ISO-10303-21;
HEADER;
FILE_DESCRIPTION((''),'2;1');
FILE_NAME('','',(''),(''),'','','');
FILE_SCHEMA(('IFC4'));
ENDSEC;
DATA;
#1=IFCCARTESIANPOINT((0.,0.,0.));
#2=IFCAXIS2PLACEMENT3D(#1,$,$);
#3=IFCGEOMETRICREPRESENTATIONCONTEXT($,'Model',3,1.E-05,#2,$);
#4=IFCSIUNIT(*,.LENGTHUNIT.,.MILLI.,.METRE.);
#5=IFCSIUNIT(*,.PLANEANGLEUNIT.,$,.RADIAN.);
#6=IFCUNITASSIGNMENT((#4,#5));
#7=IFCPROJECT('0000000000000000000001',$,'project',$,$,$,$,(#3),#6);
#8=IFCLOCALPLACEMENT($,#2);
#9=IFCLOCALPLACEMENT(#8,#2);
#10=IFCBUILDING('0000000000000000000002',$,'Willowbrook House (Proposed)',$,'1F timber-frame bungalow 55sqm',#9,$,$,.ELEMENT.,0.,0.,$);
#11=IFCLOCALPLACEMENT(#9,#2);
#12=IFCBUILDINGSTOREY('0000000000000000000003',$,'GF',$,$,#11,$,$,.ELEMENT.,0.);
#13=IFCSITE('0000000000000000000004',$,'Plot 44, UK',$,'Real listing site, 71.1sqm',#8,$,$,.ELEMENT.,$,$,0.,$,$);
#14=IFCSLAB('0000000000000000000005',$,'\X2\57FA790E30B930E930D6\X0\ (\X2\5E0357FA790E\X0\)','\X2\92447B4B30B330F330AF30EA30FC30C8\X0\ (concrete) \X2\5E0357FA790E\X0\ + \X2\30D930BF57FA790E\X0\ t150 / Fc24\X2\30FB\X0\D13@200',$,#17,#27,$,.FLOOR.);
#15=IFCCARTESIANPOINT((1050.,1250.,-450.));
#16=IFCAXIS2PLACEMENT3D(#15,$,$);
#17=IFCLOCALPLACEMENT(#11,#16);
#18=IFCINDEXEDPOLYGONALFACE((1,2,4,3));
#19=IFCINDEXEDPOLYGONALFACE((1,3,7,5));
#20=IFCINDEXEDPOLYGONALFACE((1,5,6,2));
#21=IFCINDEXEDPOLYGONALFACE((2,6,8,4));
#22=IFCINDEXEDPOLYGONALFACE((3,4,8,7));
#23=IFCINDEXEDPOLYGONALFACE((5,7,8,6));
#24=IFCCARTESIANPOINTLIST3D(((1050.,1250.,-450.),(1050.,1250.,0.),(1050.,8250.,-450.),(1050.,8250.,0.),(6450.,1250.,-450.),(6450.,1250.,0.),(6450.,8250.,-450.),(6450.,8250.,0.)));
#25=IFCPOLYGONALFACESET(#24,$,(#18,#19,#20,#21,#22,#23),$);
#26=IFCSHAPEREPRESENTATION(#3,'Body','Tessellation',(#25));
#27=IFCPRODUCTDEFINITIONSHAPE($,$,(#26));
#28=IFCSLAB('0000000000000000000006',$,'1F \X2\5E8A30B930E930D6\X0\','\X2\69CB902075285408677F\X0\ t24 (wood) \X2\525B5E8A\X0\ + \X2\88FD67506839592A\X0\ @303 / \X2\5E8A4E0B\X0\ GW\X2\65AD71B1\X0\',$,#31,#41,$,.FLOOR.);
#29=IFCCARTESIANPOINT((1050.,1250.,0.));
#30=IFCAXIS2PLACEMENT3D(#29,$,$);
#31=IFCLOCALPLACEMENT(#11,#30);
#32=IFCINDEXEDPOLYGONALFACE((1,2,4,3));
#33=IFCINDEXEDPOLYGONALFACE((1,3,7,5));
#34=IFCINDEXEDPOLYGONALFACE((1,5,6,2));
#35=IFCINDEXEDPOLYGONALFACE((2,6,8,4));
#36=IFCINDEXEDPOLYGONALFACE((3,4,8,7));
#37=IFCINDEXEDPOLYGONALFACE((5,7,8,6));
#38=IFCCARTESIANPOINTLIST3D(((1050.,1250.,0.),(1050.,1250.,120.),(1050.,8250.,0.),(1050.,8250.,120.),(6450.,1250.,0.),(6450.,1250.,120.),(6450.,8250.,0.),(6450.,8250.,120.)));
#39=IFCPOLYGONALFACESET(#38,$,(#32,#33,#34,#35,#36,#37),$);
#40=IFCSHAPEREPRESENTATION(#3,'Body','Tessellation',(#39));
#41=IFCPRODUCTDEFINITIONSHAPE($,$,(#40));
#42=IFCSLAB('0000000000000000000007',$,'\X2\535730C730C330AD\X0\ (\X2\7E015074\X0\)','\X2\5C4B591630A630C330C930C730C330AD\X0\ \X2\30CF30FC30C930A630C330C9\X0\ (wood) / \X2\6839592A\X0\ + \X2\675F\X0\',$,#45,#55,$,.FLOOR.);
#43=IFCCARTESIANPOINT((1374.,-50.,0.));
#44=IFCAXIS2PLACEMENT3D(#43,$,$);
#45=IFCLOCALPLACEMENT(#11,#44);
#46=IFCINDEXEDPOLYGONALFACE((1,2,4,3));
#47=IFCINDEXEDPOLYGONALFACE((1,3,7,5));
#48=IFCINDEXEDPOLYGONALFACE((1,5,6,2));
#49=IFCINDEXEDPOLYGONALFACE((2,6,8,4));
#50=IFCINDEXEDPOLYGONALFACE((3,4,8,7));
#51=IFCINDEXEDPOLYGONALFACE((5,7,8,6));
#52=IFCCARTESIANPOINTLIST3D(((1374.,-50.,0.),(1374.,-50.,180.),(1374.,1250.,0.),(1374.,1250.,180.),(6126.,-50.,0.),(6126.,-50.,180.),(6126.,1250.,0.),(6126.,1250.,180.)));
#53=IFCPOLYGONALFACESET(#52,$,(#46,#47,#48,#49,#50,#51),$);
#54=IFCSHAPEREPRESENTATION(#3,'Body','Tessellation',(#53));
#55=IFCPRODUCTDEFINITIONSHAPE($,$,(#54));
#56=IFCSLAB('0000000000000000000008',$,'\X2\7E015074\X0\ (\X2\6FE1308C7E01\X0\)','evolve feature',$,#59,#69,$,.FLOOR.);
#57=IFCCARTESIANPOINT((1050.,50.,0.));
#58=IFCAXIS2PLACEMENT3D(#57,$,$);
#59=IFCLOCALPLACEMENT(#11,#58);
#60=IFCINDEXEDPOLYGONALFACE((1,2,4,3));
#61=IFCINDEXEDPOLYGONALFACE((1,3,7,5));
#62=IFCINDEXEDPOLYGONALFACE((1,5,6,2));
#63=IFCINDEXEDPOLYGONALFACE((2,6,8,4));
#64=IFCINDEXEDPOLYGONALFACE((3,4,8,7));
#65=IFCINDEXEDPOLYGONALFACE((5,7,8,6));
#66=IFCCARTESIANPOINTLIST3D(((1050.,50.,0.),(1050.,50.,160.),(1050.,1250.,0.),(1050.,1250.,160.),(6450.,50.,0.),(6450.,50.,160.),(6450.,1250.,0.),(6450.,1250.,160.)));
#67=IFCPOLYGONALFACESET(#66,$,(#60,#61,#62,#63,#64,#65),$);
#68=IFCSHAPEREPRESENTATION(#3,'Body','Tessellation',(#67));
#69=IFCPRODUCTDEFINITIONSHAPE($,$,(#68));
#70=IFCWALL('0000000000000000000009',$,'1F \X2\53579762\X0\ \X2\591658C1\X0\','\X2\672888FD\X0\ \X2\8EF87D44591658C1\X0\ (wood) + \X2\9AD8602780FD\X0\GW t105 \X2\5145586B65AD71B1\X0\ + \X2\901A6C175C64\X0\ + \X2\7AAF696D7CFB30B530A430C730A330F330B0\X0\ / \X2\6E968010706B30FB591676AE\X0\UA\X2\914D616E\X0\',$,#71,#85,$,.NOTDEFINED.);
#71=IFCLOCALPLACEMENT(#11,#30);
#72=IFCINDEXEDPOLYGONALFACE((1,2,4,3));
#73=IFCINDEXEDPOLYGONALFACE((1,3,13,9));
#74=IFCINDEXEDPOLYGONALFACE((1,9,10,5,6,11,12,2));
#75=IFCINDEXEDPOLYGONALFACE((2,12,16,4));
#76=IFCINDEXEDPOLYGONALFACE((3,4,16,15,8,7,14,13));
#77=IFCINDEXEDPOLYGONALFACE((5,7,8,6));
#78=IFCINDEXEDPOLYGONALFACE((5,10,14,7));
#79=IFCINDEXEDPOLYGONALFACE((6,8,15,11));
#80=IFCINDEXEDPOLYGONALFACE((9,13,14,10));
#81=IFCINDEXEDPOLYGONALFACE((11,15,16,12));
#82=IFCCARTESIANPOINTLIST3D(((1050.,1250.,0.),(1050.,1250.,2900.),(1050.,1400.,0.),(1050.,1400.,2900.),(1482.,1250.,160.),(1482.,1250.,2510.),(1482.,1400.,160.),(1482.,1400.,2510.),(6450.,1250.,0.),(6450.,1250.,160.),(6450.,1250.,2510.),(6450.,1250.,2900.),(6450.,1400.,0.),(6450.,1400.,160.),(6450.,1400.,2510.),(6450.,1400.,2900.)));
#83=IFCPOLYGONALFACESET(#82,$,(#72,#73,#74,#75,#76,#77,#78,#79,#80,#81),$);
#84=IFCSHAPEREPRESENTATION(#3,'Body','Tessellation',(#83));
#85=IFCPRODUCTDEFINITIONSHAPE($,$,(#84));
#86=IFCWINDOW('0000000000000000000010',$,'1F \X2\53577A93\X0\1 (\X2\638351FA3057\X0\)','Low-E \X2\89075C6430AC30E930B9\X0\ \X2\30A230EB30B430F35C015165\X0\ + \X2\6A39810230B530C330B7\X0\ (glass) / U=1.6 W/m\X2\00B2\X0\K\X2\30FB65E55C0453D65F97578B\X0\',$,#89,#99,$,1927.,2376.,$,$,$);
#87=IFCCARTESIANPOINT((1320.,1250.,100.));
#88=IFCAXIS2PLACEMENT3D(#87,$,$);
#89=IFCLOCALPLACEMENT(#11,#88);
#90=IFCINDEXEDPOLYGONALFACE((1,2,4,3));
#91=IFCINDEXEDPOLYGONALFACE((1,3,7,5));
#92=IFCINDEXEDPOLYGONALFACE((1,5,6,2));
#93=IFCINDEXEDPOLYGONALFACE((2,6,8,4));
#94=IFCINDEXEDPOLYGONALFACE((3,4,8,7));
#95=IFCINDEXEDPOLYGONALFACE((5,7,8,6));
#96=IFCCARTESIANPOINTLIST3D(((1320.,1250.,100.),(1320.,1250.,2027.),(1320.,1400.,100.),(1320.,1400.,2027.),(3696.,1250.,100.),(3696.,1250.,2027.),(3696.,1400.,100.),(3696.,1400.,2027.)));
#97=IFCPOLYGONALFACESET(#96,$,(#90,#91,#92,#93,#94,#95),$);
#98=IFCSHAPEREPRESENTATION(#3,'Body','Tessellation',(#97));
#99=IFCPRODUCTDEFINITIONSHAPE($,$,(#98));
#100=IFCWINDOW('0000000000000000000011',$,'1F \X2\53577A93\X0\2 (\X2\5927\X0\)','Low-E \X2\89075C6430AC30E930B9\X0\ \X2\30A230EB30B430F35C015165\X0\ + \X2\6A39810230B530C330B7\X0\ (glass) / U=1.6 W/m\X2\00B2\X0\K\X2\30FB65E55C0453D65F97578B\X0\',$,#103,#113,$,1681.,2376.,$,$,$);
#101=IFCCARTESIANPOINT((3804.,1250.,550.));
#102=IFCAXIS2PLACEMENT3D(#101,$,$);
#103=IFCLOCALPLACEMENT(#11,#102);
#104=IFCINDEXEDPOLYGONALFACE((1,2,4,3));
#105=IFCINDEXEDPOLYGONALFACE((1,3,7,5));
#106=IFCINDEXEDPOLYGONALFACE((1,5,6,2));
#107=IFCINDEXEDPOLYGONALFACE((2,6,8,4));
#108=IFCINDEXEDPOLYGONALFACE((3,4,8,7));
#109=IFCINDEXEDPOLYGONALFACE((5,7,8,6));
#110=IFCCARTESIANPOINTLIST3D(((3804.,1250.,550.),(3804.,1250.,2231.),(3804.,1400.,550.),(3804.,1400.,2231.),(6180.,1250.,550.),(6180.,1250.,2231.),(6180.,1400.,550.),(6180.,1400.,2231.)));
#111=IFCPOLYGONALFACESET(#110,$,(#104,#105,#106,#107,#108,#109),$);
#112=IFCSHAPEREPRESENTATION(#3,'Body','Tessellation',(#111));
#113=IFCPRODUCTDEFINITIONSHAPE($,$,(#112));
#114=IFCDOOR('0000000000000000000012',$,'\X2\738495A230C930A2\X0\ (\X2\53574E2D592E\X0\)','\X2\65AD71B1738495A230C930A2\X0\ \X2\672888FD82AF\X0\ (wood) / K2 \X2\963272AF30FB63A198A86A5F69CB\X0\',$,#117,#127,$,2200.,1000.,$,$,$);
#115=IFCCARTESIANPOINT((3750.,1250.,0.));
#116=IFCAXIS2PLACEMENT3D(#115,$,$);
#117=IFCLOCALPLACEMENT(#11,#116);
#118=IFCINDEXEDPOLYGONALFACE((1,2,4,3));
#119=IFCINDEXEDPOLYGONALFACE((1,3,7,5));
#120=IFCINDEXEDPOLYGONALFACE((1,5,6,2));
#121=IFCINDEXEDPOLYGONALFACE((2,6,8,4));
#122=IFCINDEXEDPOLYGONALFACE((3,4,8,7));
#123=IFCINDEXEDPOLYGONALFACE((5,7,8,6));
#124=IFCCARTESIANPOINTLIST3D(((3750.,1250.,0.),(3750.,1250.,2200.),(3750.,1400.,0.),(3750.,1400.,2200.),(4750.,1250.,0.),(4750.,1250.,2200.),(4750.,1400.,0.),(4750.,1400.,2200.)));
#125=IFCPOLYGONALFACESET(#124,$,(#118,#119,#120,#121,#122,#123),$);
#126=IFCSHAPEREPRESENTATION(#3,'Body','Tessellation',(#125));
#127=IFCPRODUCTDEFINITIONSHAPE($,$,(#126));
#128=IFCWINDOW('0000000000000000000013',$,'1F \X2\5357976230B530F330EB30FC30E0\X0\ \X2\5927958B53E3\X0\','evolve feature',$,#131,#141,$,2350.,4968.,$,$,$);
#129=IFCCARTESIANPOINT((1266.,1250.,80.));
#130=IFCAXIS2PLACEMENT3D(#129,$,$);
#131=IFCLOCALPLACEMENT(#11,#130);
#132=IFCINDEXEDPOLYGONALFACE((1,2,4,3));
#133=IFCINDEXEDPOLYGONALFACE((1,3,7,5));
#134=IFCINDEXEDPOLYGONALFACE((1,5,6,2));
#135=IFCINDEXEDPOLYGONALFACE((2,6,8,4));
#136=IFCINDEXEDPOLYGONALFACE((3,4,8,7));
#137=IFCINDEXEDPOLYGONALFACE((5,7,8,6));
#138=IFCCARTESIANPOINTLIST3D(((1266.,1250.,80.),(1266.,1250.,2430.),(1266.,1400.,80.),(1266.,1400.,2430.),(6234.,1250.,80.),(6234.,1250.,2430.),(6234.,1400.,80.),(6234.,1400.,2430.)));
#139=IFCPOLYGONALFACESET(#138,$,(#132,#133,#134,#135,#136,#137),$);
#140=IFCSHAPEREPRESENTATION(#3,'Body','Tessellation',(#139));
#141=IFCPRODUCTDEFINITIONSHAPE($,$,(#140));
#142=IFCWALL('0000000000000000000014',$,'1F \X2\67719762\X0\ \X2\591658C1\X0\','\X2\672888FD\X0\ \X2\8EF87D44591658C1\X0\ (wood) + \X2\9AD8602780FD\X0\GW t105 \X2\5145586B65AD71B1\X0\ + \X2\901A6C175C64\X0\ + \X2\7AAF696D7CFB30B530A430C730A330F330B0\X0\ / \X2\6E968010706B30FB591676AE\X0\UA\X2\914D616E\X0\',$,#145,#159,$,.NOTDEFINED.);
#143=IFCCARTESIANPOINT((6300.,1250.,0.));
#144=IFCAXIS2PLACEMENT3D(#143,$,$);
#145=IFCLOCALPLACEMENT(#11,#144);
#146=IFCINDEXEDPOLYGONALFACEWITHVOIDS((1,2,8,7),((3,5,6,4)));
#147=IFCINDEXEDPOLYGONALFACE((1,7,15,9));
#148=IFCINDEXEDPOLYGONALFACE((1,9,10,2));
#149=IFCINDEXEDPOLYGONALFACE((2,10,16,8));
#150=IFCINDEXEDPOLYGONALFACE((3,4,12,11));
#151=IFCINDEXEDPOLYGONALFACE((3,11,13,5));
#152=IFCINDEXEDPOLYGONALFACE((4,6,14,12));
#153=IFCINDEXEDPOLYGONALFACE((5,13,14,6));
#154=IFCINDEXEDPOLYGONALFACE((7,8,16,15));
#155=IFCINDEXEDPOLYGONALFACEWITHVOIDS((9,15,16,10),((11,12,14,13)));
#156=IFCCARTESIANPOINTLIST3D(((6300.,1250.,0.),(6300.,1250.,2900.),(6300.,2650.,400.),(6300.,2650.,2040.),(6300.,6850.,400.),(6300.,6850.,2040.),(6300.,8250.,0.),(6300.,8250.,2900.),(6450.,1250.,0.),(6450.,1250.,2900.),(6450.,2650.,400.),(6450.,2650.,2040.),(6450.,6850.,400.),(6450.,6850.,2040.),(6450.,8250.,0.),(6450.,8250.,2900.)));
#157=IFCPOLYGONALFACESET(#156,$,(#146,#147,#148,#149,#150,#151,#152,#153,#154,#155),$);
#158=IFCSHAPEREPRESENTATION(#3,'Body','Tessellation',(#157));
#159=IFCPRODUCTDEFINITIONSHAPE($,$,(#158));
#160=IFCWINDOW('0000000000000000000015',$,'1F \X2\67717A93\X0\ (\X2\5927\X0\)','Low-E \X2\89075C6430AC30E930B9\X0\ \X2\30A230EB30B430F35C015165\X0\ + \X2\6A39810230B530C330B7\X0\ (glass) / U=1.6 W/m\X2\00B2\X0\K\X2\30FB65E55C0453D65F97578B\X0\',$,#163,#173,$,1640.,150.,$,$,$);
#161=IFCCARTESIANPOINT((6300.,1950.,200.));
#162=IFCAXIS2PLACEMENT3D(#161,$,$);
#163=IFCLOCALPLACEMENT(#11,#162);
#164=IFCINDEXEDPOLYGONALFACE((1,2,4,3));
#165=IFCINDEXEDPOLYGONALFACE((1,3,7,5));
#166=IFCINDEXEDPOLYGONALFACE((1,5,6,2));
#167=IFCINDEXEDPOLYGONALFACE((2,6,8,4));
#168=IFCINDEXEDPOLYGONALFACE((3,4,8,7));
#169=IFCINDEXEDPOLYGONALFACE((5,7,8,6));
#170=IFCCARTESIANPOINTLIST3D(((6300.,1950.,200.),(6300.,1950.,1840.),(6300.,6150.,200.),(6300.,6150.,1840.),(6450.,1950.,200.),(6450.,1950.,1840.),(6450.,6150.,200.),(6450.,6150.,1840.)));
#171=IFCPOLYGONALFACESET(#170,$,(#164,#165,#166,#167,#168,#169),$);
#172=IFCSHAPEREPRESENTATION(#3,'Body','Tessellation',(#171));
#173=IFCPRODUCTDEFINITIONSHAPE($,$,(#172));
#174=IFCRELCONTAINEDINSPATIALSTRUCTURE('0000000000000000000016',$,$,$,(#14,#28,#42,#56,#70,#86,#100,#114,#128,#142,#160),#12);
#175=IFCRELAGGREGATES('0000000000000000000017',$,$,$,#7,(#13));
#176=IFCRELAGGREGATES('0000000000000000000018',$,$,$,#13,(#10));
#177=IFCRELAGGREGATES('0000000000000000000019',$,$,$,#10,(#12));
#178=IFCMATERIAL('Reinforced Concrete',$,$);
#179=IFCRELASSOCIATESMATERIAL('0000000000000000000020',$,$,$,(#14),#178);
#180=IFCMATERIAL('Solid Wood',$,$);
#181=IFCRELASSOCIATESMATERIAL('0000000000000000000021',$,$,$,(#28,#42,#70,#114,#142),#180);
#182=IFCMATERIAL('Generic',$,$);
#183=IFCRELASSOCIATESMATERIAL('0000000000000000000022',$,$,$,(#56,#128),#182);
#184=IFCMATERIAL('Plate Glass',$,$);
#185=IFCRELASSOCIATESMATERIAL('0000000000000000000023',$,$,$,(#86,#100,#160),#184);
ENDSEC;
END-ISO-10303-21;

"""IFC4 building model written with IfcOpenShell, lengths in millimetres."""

from ifc_helpers import new_model, si_unit, frame, frame_2d, origin, place, context, project, spatial, rectangle, extrude, material, element, fill, save


model = new_model("IFC4")

# Units and contexts
model_context = context("Model", 3, precision=1e-05, world=origin())
ifc_project = project(units=[si_unit("LENGTHUNIT", "METRE", prefix="MILLI"), si_unit("PLANEANGLEUNIT", "RADIAN")], contexts=[model_context])

# Site, building, storey
site_placement = place(None, origin())
site = spatial("IfcSite", under=ifc_project, at=site_placement, Name="Plot 44, UK", ObjectType="Real listing site, 71.1sqm", CompositionType="ELEMENT", RefElevation=0.0)
building_placement = place(site_placement, origin())
building = spatial("IfcBuilding", under=site, at=building_placement, Name="Willowbrook House (Proposed)", ObjectType="1F timber-frame bungalow 55sqm", CompositionType="ELEMENT", ElevationOfRefHeight=0.0, ElevationOfTerrain=0.0)
storey_placement = place(building_placement, origin())
storey = spatial("IfcBuildingStorey", under=building, at=storey_placement, Name="GF", CompositionType="ELEMENT", Elevation=0.0)

# Slabs
ifc_material_1 = material(Name="Reinforced Concrete")
slab_1_placement = place(storey_placement, frame((1050.0, 1250.0, -450.0)))
element("IfcSlab", 1, at=slab_1_placement, inside=storey, material=ifc_material_1, Name="基礎スラブ (布基礎)", Description="鉄筋コンクリート (concrete) 布基礎 + ベタ基礎 t150 / Fc24・D13@200", PredefinedType="FLOOR", context=model_context, shape_type="SweptSolid", body=[
    extrude(rectangle(XDim=5400.0, YDim=7000.0, at=frame_2d((2700.0, 3500.0))), frame((1050.0, 1250.0, -450.0)), (0.0, 0.0, 1.0), 450.0),
])
ifc_material_2 = material(Name="Solid Wood")
slab_2_placement = place(storey_placement, frame((1050.0, 1250.0, 0.0)))
element("IfcSlab", 2, at=slab_2_placement, inside=storey, material=ifc_material_2, Name="1F 床スラブ", Description="構造用合板 t24 (wood) 剛床 + 製材根太 @303 / 床下 GW断熱", PredefinedType="FLOOR", context=model_context, shape_type="SweptSolid", body=[
    extrude(rectangle(XDim=5400.0, YDim=7000.0, at=frame_2d((2700.0, 3500.0))), frame((1050.0, 1250.0, 0.0)), (0.0, 0.0, 1.0), 120.0),
])
slab_3_placement = place(storey_placement, frame((1374.0, -50.0, 0.0)))
element("IfcSlab", 3, at=slab_3_placement, inside=storey, material=ifc_material_2, Name="南デッキ (縁側)", Description="屋外ウッドデッキ ハードウッド (wood) / 根太 + 束", PredefinedType="FLOOR", context=model_context, shape_type="SweptSolid", body=[
    extrude(rectangle(XDim=4752.0, YDim=1300.0, at=frame_2d((2376.0, 650.0))), frame((1374.0, -50.0, 0.0)), (0.0, 0.0, 1.0), 180.0),
])
ifc_material_3 = material(Name="Generic")
slab_4_placement = place(storey_placement, frame((1050.0, 50.0, 0.0)))
element("IfcSlab", 4, at=slab_4_placement, inside=storey, material=ifc_material_3, Name="縁側 (濡れ縁)", Description="evolve feature", PredefinedType="FLOOR", context=model_context, shape_type="SweptSolid", body=[
    extrude(rectangle(XDim=5400.0, YDim=1200.0, at=frame_2d((2700.0, 600.0))), frame((1050.0, 50.0, 0.0)), (0.0, 0.0, 1.0), 160.0),
])

# Wall, openings, windows, door
wall_1_placement = place(storey_placement, frame((1050.0, 1250.0, 0.0)))
wall_1 = element("IfcWall", 5, at=wall_1_placement, inside=storey, material=ifc_material_2, Name="1F 南面 外壁", Description="木製 軸組外壁 (wood) + 高性能GW t105 充填断熱 + 通気層 + 窯業系サイディング / 準耐火・外皮UA配慮", PredefinedType="NOTDEFINED", context=model_context, shape_type="SweptSolid", body=[
    extrude(rectangle(XDim=5400.0, YDim=150.0, at=frame_2d((2700.0, 75.0))), frame((1050.0, 1250.0, 0.0)), (0.0, 0.0, 1.0), 2900.0),
])
opening_1_placement = place(storey_placement, frame((1320.0, 1250.0, 100.0)))
opening_1 = element("IfcOpeningElement", 6, at=opening_1_placement, cuts=wall_1, PredefinedType="NOTDEFINED", context=model_context, shape_type="SweptSolid", body=[
    extrude(rectangle(XDim=2376.0, YDim=150.0, at=frame_2d((1188.0, 75.0))), frame((1320.0, 1250.0, 100.0)), (0.0, 0.0, 1.0), 1927.0),
])
opening_2_placement = place(storey_placement, frame((3804.0, 1250.0, 550.0)))
opening_2 = element("IfcOpeningElement", 7, at=opening_2_placement, cuts=wall_1, PredefinedType="NOTDEFINED", context=model_context, shape_type="SweptSolid", body=[
    extrude(rectangle(XDim=2376.0, YDim=150.0, at=frame_2d((1188.0, 75.0))), frame((3804.0, 1250.0, 550.0)), (0.0, 0.0, 1.0), 1681.0),
])
opening_3_placement = place(storey_placement, frame((3750.0, 1250.0, 0.0)))
opening_3 = element("IfcOpeningElement", 8, at=opening_3_placement, cuts=wall_1, PredefinedType="NOTDEFINED", context=model_context, shape_type="SweptSolid", body=[
    extrude(rectangle(XDim=1000.0, YDim=150.0, at=frame_2d((500.0, 75.0))), frame((3750.0, 1250.0, 0.0)), (0.0, 0.0, 1.0), 2200.0),
])
opening_4_placement = place(storey_placement, frame((1266.0, 1250.0, 80.0)))
opening_4 = element("IfcOpeningElement", 9, at=opening_4_placement, cuts=wall_1, PredefinedType="NOTDEFINED", context=model_context, shape_type="SweptSolid", body=[
    extrude(rectangle(XDim=4968.0, YDim=150.0, at=frame_2d((2484.0, 75.0))), frame((1266.0, 1250.0, 80.0)), (0.0, 0.0, 1.0), 2350.0),
])
ifc_material_4 = material(Name="Plate Glass")
window_1_placement = place(storey_placement, frame((1320.0, 1250.0, 100.0)))
window_1 = element("IfcWindow", 10, at=window_1_placement, inside=storey, material=ifc_material_4, Name="1F 南窓1 (掃出し)", Description="Low-E 複層ガラス アルゴン封入 + 樹脂サッシ (glass) / U=1.6 W/m²K・日射取得型", OverallHeight=1927.0, OverallWidth=2376.0, context=model_context, shape_type="SweptSolid", body=[
    extrude(rectangle(XDim=2376.0, YDim=150.0, at=frame_2d((1188.0, 75.0))), frame((1320.0, 1250.0, 100.0)), (0.0, 0.0, 1.0), 1927.0),
])
fill(opening_1, window_1)
window_2_placement = place(storey_placement, frame((3804.0, 1250.0, 550.0)))
window_2 = element("IfcWindow", 11, at=window_2_placement, inside=storey, material=ifc_material_4, Name="1F 南窓2 (大)", Description="Low-E 複層ガラス アルゴン封入 + 樹脂サッシ (glass) / U=1.6 W/m²K・日射取得型", OverallHeight=1681.0, OverallWidth=2376.0, context=model_context, shape_type="SweptSolid", body=[
    extrude(rectangle(XDim=2376.0, YDim=150.0, at=frame_2d((1188.0, 75.0))), frame((3804.0, 1250.0, 550.0)), (0.0, 0.0, 1.0), 1681.0),
])
fill(opening_2, window_2)
door_placement = place(storey_placement, frame((3750.0, 1250.0, 0.0)))
door = element("IfcDoor", 12, at=door_placement, inside=storey, material=ifc_material_2, Name="玄関ドア (南中央)", Description="断熱玄関ドア 木製芯 (wood) / K2 防犯・採風機構", OverallHeight=2200.0, OverallWidth=1000.0, context=model_context, shape_type="SweptSolid", body=[
    extrude(rectangle(XDim=1000.0, YDim=150.0, at=frame_2d((500.0, 75.0))), frame((3750.0, 1250.0, 0.0)), (0.0, 0.0, 1.0), 2200.0),
])
fill(opening_3, door)
window_3_placement = place(storey_placement, frame((1266.0, 1250.0, 80.0)))
window_3 = element("IfcWindow", 13, at=window_3_placement, inside=storey, material=ifc_material_3, Name="1F 南面サンルーム 大開口", Description="evolve feature", OverallHeight=2350.0, OverallWidth=4968.0, context=model_context, shape_type="SweptSolid", body=[
    extrude(rectangle(XDim=4968.0, YDim=150.0, at=frame_2d((2484.0, 75.0))), frame((1266.0, 1250.0, 80.0)), (0.0, 0.0, 1.0), 2350.0),
])
fill(opening_4, window_3)

# Wall, opening, window
wall_2_placement = place(storey_placement, frame((6300.0, 1250.0, 0.0)))
wall_2 = element("IfcWall", 14, at=wall_2_placement, inside=storey, material=ifc_material_2, Name="1F 東面 外壁", Description="木製 軸組外壁 (wood) + 高性能GW t105 充填断熱 + 通気層 + 窯業系サイディング / 準耐火・外皮UA配慮", PredefinedType="NOTDEFINED", context=model_context, shape_type="SweptSolid", body=[
    extrude(rectangle(XDim=150.0, YDim=7000.0, at=frame_2d((75.0, 3500.0))), frame((6300.0, 1250.0, 0.0)), (0.0, 0.0, 1.0), 2900.0),
])
opening_5_placement = place(storey_placement, frame((6300.0, 1950.0, 200.0)))
opening_5 = element("IfcOpeningElement", 15, at=opening_5_placement, cuts=wall_2, PredefinedType="NOTDEFINED", context=model_context, shape_type="SweptSolid", body=[
    extrude(rectangle(XDim=150.0, YDim=4200.0, at=frame_2d((75.0, 2100.0))), frame((6300.0, 1950.0, 200.0)), (0.0, 0.0, 1.0), 1640.0),
])
window_4_placement = place(storey_placement, frame((6300.0, 1950.0, 200.0)))
window_4 = element("IfcWindow", 16, at=window_4_placement, inside=storey, material=ifc_material_4, Name="1F 東窓 (大)", Description="Low-E 複層ガラス アルゴン封入 + 樹脂サッシ (glass) / U=1.6 W/m²K・日射取得型", OverallHeight=1640.0, OverallWidth=150.0, context=model_context, shape_type="SweptSolid", body=[
    extrude(rectangle(XDim=150.0, YDim=4200.0, at=frame_2d((75.0, 2100.0))), frame((6300.0, 1950.0, 200.0)), (0.0, 0.0, 1.0), 1640.0),
])
fill(opening_5, window_4)

save(model, "model.ifc")
